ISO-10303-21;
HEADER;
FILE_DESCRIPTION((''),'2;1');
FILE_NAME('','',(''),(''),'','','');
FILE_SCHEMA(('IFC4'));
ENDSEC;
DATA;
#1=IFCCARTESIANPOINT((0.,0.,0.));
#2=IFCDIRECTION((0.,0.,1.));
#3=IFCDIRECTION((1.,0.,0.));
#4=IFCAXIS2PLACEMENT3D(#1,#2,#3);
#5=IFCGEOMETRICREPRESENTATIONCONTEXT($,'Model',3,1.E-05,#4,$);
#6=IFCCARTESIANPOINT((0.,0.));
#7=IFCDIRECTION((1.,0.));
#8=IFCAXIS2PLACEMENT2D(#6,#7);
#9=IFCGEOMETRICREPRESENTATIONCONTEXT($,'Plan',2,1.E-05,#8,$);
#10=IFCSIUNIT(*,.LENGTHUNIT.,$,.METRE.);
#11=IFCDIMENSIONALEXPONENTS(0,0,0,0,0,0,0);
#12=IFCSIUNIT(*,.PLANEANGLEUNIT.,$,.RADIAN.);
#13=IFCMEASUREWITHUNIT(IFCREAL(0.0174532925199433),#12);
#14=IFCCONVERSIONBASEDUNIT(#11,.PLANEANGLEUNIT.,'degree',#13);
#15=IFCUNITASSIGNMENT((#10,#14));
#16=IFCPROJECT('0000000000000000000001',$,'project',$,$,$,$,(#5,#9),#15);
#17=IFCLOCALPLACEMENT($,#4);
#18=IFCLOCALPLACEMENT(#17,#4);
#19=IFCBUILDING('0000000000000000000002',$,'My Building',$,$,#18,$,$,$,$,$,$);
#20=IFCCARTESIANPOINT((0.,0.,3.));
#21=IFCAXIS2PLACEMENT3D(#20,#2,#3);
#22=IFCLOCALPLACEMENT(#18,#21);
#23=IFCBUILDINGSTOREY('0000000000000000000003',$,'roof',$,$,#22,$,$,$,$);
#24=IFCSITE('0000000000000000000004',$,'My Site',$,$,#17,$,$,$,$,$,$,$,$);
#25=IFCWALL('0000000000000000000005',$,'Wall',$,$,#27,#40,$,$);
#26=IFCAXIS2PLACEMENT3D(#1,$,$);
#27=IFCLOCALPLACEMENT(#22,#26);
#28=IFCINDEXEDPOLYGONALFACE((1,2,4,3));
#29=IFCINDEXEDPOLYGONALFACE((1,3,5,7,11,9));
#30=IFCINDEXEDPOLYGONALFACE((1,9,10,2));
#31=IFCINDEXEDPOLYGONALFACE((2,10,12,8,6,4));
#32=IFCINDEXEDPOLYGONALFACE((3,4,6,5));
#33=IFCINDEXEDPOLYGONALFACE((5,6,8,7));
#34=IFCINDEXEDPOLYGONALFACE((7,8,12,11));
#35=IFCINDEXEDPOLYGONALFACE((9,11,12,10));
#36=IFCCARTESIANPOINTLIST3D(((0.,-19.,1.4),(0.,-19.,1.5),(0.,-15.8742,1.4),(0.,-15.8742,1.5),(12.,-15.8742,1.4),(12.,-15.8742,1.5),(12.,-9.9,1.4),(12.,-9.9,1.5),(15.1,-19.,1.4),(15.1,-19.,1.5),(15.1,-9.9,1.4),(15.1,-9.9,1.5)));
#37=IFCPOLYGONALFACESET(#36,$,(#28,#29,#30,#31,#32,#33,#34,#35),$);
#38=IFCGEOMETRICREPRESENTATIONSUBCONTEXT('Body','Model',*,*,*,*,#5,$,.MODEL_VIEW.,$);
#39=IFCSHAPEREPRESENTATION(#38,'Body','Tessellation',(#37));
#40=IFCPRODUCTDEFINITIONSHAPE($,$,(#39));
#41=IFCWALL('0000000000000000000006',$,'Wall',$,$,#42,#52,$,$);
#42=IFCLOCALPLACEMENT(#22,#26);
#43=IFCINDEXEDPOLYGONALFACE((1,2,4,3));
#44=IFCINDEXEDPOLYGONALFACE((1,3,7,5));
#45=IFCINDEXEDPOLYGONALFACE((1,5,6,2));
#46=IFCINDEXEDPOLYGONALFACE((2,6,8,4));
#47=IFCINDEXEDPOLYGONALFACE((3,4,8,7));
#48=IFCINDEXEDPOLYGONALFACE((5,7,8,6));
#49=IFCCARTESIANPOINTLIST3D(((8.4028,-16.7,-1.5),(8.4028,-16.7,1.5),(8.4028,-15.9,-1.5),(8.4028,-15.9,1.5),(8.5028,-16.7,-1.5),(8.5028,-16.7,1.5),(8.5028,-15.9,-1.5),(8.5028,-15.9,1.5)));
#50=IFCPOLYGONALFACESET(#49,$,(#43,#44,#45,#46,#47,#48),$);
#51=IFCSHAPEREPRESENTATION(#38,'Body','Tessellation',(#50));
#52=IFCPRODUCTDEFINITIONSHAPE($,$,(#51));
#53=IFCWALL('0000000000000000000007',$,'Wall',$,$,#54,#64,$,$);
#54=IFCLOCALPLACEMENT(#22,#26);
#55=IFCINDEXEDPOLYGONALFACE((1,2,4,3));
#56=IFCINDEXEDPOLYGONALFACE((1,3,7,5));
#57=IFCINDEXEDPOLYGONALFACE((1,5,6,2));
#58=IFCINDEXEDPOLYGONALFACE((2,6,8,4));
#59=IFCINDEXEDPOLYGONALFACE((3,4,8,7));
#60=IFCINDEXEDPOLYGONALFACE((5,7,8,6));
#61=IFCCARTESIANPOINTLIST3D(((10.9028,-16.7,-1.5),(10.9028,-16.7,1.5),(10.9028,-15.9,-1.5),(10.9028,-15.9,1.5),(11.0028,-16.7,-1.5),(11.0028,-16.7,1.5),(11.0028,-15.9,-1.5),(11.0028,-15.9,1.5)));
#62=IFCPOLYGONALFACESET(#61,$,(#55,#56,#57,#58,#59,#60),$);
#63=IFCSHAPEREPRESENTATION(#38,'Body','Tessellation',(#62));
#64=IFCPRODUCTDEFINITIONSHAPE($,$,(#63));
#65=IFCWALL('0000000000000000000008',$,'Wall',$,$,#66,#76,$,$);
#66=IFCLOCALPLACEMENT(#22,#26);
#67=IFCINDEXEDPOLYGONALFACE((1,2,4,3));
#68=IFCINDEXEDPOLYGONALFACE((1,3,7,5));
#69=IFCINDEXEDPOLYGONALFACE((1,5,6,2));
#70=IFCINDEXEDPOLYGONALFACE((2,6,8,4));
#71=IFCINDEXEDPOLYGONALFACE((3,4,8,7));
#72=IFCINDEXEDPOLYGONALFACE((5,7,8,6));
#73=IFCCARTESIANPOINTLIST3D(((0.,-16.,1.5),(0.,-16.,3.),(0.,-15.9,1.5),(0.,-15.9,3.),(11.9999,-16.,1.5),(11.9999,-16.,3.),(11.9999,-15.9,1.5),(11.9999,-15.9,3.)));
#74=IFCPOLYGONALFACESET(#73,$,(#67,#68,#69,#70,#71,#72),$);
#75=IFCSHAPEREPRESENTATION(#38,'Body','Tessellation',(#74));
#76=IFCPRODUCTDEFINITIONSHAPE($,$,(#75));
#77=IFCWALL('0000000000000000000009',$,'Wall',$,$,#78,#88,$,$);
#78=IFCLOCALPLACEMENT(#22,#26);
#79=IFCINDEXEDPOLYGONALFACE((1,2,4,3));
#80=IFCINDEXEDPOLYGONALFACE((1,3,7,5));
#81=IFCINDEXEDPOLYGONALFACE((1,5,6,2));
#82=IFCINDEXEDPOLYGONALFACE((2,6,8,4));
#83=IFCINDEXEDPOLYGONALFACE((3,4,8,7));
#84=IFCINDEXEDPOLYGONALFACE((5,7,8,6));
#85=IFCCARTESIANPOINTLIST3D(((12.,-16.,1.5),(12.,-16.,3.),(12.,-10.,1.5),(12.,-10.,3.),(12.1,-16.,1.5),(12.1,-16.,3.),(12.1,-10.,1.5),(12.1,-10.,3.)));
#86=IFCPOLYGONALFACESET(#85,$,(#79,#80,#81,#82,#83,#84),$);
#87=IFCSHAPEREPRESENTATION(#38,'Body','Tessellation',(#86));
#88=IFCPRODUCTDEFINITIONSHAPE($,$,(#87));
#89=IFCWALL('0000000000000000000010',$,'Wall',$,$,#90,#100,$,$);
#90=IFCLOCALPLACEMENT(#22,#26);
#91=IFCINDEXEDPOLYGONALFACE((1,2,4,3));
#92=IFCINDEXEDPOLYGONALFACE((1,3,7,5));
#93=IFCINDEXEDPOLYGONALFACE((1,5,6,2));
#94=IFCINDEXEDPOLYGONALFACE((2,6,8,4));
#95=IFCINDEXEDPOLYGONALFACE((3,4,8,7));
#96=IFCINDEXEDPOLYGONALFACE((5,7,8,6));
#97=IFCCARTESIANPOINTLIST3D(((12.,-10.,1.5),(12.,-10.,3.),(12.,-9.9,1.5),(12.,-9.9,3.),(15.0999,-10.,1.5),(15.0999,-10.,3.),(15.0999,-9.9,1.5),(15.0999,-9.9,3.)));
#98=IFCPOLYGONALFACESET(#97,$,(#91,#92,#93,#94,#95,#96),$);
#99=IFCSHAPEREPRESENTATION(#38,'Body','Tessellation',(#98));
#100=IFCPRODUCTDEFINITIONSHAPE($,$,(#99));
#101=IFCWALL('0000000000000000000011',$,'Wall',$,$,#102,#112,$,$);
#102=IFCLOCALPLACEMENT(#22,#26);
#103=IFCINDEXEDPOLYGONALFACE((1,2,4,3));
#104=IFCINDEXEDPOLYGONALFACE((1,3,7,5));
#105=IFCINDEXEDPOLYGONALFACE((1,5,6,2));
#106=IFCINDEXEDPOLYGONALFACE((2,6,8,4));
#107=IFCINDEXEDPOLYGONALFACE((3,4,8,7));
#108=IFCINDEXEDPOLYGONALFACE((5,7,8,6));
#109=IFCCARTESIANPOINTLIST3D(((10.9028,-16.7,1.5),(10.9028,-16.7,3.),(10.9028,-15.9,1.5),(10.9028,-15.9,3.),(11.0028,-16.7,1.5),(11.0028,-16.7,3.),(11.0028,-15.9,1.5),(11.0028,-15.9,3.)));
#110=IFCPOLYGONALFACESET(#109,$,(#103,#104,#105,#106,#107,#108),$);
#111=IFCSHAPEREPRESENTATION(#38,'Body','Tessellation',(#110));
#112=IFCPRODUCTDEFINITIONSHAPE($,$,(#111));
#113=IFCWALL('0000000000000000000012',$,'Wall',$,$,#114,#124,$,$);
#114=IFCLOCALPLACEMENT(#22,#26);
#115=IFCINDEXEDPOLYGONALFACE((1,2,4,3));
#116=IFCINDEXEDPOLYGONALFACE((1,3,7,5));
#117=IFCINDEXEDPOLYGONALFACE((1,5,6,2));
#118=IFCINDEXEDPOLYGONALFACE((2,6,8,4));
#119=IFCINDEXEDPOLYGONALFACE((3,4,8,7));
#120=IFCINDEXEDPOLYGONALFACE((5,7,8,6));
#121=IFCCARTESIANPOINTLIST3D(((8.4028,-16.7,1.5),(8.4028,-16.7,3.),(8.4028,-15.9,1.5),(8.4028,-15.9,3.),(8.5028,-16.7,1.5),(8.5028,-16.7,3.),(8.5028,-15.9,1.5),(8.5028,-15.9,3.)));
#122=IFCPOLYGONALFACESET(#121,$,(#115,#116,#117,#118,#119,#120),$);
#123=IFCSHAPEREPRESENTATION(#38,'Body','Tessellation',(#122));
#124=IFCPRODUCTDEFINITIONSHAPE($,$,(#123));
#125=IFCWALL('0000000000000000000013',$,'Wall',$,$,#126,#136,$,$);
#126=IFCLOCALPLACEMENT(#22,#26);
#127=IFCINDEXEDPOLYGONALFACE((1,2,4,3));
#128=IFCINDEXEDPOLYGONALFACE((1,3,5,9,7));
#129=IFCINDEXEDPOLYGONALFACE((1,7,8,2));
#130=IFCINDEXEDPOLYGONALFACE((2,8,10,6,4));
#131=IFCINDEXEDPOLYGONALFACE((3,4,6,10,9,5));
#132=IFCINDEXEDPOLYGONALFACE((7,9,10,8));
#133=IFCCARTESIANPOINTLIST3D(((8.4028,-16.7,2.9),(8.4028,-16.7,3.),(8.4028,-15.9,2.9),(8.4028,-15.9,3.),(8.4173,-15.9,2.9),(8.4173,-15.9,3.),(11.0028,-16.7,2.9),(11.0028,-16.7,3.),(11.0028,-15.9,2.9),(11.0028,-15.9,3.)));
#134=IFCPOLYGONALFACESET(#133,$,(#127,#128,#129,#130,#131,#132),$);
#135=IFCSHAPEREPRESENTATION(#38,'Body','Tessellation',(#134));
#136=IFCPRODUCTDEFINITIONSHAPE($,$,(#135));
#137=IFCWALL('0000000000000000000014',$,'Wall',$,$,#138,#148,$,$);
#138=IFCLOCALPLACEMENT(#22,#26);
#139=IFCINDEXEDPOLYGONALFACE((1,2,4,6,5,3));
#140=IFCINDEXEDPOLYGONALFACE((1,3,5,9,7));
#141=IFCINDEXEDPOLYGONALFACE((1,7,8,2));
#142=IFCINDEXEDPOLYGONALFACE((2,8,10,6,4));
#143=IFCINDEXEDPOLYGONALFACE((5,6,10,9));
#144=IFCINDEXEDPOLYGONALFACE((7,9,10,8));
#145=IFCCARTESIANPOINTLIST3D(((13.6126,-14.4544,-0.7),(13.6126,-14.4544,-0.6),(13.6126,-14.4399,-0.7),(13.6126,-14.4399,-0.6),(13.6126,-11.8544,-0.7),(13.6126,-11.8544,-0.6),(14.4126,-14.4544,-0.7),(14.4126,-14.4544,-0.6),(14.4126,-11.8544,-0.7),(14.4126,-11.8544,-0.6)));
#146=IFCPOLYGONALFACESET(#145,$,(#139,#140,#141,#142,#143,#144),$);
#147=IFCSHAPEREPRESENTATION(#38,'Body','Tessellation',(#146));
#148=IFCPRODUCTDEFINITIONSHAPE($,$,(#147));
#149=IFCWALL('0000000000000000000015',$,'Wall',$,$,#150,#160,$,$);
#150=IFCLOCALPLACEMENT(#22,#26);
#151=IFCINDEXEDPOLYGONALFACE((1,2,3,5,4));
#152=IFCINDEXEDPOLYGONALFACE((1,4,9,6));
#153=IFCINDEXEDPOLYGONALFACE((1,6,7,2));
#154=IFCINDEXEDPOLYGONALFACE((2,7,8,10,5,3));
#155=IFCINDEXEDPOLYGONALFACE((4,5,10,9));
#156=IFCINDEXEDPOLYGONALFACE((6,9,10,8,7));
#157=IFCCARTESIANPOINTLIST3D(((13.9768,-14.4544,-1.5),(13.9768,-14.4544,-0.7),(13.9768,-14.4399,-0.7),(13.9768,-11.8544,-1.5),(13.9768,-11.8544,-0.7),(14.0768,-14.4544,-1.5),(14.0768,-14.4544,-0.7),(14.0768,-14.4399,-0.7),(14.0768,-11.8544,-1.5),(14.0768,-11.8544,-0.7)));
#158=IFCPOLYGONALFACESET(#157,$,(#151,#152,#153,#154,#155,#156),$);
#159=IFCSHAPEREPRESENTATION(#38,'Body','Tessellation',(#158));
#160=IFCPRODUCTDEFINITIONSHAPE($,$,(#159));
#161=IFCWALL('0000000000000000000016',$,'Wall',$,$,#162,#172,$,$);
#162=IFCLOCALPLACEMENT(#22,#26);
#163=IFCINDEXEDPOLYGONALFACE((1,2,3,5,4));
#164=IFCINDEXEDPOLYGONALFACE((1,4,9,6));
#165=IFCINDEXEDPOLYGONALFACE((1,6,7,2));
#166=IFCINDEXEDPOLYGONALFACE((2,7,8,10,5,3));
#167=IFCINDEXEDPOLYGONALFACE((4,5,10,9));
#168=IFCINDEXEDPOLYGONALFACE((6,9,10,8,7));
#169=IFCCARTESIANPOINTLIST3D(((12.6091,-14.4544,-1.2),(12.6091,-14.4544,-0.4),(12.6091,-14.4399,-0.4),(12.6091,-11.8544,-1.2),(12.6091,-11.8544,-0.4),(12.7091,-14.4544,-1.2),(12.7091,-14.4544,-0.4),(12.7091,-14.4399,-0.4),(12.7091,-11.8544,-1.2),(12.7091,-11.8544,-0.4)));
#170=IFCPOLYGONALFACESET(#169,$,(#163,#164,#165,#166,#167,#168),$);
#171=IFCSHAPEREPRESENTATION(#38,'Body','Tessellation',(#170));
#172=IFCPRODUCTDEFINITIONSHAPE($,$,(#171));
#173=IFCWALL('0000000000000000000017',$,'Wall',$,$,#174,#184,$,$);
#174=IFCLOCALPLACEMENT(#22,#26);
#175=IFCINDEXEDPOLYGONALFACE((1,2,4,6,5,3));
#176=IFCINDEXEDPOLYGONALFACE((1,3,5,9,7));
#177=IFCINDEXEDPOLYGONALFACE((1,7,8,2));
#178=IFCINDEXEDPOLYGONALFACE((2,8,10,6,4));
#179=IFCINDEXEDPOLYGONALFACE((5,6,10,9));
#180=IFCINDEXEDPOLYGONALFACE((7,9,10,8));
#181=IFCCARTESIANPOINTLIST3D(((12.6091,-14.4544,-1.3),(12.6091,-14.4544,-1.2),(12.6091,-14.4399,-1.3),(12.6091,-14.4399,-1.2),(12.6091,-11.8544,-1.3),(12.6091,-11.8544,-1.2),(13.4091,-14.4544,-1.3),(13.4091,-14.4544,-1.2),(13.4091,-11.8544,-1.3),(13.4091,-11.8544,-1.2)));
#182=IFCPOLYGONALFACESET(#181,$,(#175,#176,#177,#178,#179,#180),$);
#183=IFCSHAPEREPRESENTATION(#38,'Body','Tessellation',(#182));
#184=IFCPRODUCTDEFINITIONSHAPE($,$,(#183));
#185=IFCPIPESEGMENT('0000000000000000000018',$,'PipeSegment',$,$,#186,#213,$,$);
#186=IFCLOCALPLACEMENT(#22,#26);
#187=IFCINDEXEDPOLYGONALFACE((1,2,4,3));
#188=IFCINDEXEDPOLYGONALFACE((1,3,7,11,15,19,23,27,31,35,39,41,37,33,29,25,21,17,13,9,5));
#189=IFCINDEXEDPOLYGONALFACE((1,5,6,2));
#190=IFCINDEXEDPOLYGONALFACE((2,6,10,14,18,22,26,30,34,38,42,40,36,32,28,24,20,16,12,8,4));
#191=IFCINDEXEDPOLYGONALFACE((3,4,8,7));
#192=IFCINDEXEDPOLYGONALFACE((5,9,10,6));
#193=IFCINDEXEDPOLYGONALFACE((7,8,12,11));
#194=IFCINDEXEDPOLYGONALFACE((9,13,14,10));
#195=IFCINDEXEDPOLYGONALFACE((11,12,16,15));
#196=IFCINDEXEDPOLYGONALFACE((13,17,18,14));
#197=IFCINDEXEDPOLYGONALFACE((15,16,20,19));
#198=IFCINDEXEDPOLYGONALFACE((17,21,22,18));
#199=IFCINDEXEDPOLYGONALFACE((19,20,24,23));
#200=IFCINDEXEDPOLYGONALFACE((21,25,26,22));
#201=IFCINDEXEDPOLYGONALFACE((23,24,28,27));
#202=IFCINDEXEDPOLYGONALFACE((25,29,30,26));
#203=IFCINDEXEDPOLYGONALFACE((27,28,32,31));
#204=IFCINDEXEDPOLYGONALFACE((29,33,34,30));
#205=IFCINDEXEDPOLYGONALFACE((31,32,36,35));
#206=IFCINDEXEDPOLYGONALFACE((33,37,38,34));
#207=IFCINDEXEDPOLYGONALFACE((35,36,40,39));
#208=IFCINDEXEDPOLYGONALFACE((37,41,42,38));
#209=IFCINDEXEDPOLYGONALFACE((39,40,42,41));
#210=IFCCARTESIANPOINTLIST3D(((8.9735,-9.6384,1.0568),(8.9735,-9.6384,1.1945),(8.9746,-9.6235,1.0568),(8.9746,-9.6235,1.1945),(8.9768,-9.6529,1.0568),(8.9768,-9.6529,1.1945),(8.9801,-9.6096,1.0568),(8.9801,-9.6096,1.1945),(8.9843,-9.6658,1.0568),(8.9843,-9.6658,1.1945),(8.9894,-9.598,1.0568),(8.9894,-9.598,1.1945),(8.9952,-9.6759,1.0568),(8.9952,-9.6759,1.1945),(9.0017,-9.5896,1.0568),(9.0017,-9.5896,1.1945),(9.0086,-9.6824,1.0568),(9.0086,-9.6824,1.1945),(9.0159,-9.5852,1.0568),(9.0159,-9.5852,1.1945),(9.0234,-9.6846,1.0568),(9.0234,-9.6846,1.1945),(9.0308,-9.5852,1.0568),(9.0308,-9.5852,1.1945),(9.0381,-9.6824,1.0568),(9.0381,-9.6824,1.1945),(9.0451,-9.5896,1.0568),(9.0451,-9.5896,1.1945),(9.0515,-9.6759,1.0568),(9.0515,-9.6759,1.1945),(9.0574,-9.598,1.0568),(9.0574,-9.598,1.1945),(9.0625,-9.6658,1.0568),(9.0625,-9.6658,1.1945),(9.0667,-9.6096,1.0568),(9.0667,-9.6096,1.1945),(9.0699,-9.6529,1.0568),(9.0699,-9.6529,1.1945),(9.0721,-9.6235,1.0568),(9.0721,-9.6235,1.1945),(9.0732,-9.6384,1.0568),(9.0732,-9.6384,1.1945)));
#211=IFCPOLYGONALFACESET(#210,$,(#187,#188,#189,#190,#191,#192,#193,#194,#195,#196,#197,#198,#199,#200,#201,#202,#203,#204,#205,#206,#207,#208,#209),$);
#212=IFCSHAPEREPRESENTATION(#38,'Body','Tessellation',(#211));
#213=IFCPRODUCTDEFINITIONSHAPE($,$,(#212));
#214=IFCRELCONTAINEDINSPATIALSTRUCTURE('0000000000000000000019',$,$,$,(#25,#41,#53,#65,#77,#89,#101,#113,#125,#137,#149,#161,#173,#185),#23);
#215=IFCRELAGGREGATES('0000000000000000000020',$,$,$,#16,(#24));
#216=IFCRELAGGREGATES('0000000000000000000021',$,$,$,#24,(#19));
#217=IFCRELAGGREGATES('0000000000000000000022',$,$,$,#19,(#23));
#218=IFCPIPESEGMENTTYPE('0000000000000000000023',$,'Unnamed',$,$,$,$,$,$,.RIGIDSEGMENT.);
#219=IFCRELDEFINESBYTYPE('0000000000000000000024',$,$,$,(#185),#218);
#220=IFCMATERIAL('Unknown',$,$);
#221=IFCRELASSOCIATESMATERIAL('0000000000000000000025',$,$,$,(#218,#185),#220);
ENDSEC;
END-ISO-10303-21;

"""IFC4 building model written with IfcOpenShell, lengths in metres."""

from ifc_helpers import new_model, entity, si_unit, converted_unit, frame, origin_with_axes, origin_2d_with_axis, place, context, subcontext, project, spatial, line, indexed_curve, circle, outline, extrude, material, material_profile, profile_set, profile_usage, type_object, element, save


model = new_model("IFC4")

# Units and contexts
model_context = context("Model", 3, precision=1e-05, world=origin_with_axes())
plan_context = context("Plan", 2, precision=1e-05, world=origin_2d_with_axis())
body_context_1 = subcontext(model_context, "Body", "Model", "MODEL_VIEW")
ifc_project = project(units=[si_unit("LENGTHUNIT", "METRE"), converted_unit("PLANEANGLEUNIT", "degree", entity("IfcReal", 0.0174532925199433), si_unit("PLANEANGLEUNIT", "RADIAN"), dimensions=[0, 0, 0, 0, 0, 0, 0])], contexts=[model_context, plan_context])

# Site, building, storey
site_placement = place(None, origin_with_axes())
site = spatial("IfcSite", under=ifc_project, at=site_placement, Name="My Site")
building_placement = place(site_placement, origin_with_axes())
building = spatial("IfcBuilding", under=site, at=building_placement, Name="My Building")
storey_placement = place(building_placement, frame((0.0, 0.0, 3.0), z_axis=(0.0, 0.0, 1.0), x_axis=(1.0, 0.0, 0.0)))
storey = spatial("IfcBuildingStorey", under=building, at=storey_placement, Name="roof")

# Shared definitions
ifc_material = material(Name="Unknown")

# Walls
wall_1_placement = place(storey_placement, frame((15.1, -9.9, 1.5), z_axis=(0.0, 0.0, 1.0), x_axis=(1.0, 0.0, 0.0)))
element("IfcWall", 1, at=wall_1_placement, inside=storey, Name="Wall", context=body_context_1, shape_type="SweptSolid", body=[
    extrude(outline(indexed_curve([(0.0, 0.0), (-3.1, 0.0), (-3.1, -5.9742), (-15.1, -5.9742), (-15.1, -9.1), (0.0, -9.1), (0.0, 0.0)])), frame((0.0, 0.0, -0.1), z_axis=(0.0, 0.0, 1.0), x_axis=(1.0, 0.0, 0.0)), (0.0, 0.0, 1.0), 0.1),
])
for number, where, z_axis, x_axis, name in (
    (2, (8.5028, -16.7, -1.5), (0.0, 0.0, 1.0), (0.0, 1.0, 0.0), "Wall"),
    (3, (11.0028, -16.7, -1.5), (0.0, 0.0, 1.0), (0.0, 1.0, 0.0), "Wall"),
):
    element("IfcWall", number, at=place(storey_placement, frame(where, z_axis=z_axis, x_axis=x_axis)), inside=storey, Name=name, context=body_context_1, shape_type="SweptSolid", body=[
        extrude(outline(indexed_curve([(0.0, 0.0), (0.0, 0.1), (0.8, 0.1), (0.8, 0.0)], segments=[line(1, 2, 3, 4, 1)])), origin_with_axes(), (0.0, 0.0, 1.0), 3.0),
    ])
wall_2_placement = place(storey_placement, frame((0.0, -16.0, 1.5), z_axis=(0.0, 0.0, 1.0), x_axis=(1.0, 0.0, 0.0)))
element("IfcWall", 4, at=wall_2_placement, inside=storey, Name="Wall", context=body_context_1, shape_type="SweptSolid", body=[
    extrude(outline(indexed_curve([(0.0, 0.0), (0.0, 0.1), (11.9999, 0.1), (11.9999, 0.0)], segments=[line(1, 2, 3, 4, 1)])), origin_with_axes(), (0.0, 0.0, 1.0), 1.5),
])
wall_3_placement = place(storey_placement, frame((12.1, -16.0, 1.5), z_axis=(0.0, 0.0, 1.0), x_axis=(0.0, 1.0, 0.0)))
element("IfcWall", 5, at=wall_3_placement, inside=storey, Name="Wall", context=body_context_1, shape_type="SweptSolid", body=[
    extrude(outline(indexed_curve([(0.0, 0.0), (0.0, 0.1), (6.0, 0.1), (6.0, 0.0)], segments=[line(1, 2, 3, 4, 1)])), origin_with_axes(), (0.0, 0.0, 1.0), 1.5),
])
wall_4_placement = place(storey_placement, frame((12.0, -10.0, 1.5), z_axis=(0.0, 0.0, 1.0), x_axis=(1.0, 0.0, 0.0)))
element("IfcWall", 6, at=wall_4_placement, inside=storey, Name="Wall", context=body_context_1, shape_type="SweptSolid", body=[
    extrude(outline(indexed_curve([(0.0, 0.0), (0.0, 0.1), (3.0999, 0.1), (3.0999, 0.0)], segments=[line(1, 2, 3, 4, 1)])), origin_with_axes(), (0.0, 0.0, 1.0), 1.5),
])
for number, where, z_axis, x_axis, name in (
    (7, (11.0028, -16.7, 1.5), (0.0, 0.0, 1.0), (0.0, 1.0, 0.0), "Wall"),
    (8, (8.5028, -16.7, 1.5), (0.0, 0.0, 1.0), (0.0, 1.0, 0.0), "Wall"),
):
    element("IfcWall", number, at=place(storey_placement, frame(where, z_axis=z_axis, x_axis=x_axis)), inside=storey, Name=name, context=body_context_1, shape_type="SweptSolid", body=[
        extrude(outline(indexed_curve([(0.0, 0.0), (0.0, 0.1), (0.8, 0.1), (0.8, 0.0)], segments=[line(1, 2, 3, 4, 1)])), origin_with_axes(), (0.0, 0.0, 1.0), 1.5),
    ])
for number, where, z_axis, x_axis, name in (
    (9, (8.4028, -16.7, 3.0), (0.0, 0.0, 1.0), (1.0, 0.0, 0.0), "Wall"),
    (10, (14.4126, -14.4544, -0.6), (0.0, 0.0, 1.0), (0.0, 1.0, 0.0), "Wall"),
    (11, (14.0768, -14.4544, -1.5), (1.0, 0.0, 0.0), (0.0, 1.0, 0.0), "Wall"),
    (12, (12.7091, -14.4544, -1.2), (1.0, 0.0, 0.0), (0.0, 1.0, 0.0), "Wall"),
    (13, (13.4091, -14.4544, -1.2), (0.0, 0.0, 1.0), (0.0, 1.0, 0.0), "Wall"),
):
    element("IfcWall", number, at=place(storey_placement, frame(where, z_axis=z_axis, x_axis=x_axis)), inside=storey, Name=name, context=body_context_1, shape_type="SweptSolid", body=[
        extrude(outline(indexed_curve([(0.0, 0.0), (2.6, 0.0), (2.6, 0.8), (0.0145, 0.8), (0.0, 0.8), (0.0, 0.0)])), frame((0.0, 0.0, -0.1), z_axis=(0.0, 0.0, 1.0), x_axis=(1.0, 0.0, 0.0)), (0.0, 0.0, 1.0), 0.1),
    ])

# Pipe segment
ifc_material_profile_1 = material_profile(ifc_material, circle(Radius=0.05))
ifc_profile_set_1 = profile_set([ifc_material_profile_1])
ifc_profile_usage_1 = profile_usage(ifc_profile_set_1, cardinal=5)
pipe_segment_type = type_object("IfcPipeSegmentType", Name="Unnamed", PredefinedType="RIGIDSEGMENT", material=ifc_profile_set_1)
pipe_segment_1_placement = place(storey_placement, frame((9.0234, -9.6346, 1.0568), z_axis=(0.000001, -0.000001, 1.0), x_axis=(0.0, -1.0, -0.000001)))
element("IfcPipeSegment", 14, at=pipe_segment_1_placement, inside=storey, type_object=pipe_segment_type, material=ifc_profile_usage_1, Name="PipeSegment", context=body_context_1, shape_type="SweptSolid", body=[
    extrude(circle(Radius=0.05), origin_with_axes(), (0.0, 0.0, 1.0), 0.1377),
])

save(model, "model.ifc")
